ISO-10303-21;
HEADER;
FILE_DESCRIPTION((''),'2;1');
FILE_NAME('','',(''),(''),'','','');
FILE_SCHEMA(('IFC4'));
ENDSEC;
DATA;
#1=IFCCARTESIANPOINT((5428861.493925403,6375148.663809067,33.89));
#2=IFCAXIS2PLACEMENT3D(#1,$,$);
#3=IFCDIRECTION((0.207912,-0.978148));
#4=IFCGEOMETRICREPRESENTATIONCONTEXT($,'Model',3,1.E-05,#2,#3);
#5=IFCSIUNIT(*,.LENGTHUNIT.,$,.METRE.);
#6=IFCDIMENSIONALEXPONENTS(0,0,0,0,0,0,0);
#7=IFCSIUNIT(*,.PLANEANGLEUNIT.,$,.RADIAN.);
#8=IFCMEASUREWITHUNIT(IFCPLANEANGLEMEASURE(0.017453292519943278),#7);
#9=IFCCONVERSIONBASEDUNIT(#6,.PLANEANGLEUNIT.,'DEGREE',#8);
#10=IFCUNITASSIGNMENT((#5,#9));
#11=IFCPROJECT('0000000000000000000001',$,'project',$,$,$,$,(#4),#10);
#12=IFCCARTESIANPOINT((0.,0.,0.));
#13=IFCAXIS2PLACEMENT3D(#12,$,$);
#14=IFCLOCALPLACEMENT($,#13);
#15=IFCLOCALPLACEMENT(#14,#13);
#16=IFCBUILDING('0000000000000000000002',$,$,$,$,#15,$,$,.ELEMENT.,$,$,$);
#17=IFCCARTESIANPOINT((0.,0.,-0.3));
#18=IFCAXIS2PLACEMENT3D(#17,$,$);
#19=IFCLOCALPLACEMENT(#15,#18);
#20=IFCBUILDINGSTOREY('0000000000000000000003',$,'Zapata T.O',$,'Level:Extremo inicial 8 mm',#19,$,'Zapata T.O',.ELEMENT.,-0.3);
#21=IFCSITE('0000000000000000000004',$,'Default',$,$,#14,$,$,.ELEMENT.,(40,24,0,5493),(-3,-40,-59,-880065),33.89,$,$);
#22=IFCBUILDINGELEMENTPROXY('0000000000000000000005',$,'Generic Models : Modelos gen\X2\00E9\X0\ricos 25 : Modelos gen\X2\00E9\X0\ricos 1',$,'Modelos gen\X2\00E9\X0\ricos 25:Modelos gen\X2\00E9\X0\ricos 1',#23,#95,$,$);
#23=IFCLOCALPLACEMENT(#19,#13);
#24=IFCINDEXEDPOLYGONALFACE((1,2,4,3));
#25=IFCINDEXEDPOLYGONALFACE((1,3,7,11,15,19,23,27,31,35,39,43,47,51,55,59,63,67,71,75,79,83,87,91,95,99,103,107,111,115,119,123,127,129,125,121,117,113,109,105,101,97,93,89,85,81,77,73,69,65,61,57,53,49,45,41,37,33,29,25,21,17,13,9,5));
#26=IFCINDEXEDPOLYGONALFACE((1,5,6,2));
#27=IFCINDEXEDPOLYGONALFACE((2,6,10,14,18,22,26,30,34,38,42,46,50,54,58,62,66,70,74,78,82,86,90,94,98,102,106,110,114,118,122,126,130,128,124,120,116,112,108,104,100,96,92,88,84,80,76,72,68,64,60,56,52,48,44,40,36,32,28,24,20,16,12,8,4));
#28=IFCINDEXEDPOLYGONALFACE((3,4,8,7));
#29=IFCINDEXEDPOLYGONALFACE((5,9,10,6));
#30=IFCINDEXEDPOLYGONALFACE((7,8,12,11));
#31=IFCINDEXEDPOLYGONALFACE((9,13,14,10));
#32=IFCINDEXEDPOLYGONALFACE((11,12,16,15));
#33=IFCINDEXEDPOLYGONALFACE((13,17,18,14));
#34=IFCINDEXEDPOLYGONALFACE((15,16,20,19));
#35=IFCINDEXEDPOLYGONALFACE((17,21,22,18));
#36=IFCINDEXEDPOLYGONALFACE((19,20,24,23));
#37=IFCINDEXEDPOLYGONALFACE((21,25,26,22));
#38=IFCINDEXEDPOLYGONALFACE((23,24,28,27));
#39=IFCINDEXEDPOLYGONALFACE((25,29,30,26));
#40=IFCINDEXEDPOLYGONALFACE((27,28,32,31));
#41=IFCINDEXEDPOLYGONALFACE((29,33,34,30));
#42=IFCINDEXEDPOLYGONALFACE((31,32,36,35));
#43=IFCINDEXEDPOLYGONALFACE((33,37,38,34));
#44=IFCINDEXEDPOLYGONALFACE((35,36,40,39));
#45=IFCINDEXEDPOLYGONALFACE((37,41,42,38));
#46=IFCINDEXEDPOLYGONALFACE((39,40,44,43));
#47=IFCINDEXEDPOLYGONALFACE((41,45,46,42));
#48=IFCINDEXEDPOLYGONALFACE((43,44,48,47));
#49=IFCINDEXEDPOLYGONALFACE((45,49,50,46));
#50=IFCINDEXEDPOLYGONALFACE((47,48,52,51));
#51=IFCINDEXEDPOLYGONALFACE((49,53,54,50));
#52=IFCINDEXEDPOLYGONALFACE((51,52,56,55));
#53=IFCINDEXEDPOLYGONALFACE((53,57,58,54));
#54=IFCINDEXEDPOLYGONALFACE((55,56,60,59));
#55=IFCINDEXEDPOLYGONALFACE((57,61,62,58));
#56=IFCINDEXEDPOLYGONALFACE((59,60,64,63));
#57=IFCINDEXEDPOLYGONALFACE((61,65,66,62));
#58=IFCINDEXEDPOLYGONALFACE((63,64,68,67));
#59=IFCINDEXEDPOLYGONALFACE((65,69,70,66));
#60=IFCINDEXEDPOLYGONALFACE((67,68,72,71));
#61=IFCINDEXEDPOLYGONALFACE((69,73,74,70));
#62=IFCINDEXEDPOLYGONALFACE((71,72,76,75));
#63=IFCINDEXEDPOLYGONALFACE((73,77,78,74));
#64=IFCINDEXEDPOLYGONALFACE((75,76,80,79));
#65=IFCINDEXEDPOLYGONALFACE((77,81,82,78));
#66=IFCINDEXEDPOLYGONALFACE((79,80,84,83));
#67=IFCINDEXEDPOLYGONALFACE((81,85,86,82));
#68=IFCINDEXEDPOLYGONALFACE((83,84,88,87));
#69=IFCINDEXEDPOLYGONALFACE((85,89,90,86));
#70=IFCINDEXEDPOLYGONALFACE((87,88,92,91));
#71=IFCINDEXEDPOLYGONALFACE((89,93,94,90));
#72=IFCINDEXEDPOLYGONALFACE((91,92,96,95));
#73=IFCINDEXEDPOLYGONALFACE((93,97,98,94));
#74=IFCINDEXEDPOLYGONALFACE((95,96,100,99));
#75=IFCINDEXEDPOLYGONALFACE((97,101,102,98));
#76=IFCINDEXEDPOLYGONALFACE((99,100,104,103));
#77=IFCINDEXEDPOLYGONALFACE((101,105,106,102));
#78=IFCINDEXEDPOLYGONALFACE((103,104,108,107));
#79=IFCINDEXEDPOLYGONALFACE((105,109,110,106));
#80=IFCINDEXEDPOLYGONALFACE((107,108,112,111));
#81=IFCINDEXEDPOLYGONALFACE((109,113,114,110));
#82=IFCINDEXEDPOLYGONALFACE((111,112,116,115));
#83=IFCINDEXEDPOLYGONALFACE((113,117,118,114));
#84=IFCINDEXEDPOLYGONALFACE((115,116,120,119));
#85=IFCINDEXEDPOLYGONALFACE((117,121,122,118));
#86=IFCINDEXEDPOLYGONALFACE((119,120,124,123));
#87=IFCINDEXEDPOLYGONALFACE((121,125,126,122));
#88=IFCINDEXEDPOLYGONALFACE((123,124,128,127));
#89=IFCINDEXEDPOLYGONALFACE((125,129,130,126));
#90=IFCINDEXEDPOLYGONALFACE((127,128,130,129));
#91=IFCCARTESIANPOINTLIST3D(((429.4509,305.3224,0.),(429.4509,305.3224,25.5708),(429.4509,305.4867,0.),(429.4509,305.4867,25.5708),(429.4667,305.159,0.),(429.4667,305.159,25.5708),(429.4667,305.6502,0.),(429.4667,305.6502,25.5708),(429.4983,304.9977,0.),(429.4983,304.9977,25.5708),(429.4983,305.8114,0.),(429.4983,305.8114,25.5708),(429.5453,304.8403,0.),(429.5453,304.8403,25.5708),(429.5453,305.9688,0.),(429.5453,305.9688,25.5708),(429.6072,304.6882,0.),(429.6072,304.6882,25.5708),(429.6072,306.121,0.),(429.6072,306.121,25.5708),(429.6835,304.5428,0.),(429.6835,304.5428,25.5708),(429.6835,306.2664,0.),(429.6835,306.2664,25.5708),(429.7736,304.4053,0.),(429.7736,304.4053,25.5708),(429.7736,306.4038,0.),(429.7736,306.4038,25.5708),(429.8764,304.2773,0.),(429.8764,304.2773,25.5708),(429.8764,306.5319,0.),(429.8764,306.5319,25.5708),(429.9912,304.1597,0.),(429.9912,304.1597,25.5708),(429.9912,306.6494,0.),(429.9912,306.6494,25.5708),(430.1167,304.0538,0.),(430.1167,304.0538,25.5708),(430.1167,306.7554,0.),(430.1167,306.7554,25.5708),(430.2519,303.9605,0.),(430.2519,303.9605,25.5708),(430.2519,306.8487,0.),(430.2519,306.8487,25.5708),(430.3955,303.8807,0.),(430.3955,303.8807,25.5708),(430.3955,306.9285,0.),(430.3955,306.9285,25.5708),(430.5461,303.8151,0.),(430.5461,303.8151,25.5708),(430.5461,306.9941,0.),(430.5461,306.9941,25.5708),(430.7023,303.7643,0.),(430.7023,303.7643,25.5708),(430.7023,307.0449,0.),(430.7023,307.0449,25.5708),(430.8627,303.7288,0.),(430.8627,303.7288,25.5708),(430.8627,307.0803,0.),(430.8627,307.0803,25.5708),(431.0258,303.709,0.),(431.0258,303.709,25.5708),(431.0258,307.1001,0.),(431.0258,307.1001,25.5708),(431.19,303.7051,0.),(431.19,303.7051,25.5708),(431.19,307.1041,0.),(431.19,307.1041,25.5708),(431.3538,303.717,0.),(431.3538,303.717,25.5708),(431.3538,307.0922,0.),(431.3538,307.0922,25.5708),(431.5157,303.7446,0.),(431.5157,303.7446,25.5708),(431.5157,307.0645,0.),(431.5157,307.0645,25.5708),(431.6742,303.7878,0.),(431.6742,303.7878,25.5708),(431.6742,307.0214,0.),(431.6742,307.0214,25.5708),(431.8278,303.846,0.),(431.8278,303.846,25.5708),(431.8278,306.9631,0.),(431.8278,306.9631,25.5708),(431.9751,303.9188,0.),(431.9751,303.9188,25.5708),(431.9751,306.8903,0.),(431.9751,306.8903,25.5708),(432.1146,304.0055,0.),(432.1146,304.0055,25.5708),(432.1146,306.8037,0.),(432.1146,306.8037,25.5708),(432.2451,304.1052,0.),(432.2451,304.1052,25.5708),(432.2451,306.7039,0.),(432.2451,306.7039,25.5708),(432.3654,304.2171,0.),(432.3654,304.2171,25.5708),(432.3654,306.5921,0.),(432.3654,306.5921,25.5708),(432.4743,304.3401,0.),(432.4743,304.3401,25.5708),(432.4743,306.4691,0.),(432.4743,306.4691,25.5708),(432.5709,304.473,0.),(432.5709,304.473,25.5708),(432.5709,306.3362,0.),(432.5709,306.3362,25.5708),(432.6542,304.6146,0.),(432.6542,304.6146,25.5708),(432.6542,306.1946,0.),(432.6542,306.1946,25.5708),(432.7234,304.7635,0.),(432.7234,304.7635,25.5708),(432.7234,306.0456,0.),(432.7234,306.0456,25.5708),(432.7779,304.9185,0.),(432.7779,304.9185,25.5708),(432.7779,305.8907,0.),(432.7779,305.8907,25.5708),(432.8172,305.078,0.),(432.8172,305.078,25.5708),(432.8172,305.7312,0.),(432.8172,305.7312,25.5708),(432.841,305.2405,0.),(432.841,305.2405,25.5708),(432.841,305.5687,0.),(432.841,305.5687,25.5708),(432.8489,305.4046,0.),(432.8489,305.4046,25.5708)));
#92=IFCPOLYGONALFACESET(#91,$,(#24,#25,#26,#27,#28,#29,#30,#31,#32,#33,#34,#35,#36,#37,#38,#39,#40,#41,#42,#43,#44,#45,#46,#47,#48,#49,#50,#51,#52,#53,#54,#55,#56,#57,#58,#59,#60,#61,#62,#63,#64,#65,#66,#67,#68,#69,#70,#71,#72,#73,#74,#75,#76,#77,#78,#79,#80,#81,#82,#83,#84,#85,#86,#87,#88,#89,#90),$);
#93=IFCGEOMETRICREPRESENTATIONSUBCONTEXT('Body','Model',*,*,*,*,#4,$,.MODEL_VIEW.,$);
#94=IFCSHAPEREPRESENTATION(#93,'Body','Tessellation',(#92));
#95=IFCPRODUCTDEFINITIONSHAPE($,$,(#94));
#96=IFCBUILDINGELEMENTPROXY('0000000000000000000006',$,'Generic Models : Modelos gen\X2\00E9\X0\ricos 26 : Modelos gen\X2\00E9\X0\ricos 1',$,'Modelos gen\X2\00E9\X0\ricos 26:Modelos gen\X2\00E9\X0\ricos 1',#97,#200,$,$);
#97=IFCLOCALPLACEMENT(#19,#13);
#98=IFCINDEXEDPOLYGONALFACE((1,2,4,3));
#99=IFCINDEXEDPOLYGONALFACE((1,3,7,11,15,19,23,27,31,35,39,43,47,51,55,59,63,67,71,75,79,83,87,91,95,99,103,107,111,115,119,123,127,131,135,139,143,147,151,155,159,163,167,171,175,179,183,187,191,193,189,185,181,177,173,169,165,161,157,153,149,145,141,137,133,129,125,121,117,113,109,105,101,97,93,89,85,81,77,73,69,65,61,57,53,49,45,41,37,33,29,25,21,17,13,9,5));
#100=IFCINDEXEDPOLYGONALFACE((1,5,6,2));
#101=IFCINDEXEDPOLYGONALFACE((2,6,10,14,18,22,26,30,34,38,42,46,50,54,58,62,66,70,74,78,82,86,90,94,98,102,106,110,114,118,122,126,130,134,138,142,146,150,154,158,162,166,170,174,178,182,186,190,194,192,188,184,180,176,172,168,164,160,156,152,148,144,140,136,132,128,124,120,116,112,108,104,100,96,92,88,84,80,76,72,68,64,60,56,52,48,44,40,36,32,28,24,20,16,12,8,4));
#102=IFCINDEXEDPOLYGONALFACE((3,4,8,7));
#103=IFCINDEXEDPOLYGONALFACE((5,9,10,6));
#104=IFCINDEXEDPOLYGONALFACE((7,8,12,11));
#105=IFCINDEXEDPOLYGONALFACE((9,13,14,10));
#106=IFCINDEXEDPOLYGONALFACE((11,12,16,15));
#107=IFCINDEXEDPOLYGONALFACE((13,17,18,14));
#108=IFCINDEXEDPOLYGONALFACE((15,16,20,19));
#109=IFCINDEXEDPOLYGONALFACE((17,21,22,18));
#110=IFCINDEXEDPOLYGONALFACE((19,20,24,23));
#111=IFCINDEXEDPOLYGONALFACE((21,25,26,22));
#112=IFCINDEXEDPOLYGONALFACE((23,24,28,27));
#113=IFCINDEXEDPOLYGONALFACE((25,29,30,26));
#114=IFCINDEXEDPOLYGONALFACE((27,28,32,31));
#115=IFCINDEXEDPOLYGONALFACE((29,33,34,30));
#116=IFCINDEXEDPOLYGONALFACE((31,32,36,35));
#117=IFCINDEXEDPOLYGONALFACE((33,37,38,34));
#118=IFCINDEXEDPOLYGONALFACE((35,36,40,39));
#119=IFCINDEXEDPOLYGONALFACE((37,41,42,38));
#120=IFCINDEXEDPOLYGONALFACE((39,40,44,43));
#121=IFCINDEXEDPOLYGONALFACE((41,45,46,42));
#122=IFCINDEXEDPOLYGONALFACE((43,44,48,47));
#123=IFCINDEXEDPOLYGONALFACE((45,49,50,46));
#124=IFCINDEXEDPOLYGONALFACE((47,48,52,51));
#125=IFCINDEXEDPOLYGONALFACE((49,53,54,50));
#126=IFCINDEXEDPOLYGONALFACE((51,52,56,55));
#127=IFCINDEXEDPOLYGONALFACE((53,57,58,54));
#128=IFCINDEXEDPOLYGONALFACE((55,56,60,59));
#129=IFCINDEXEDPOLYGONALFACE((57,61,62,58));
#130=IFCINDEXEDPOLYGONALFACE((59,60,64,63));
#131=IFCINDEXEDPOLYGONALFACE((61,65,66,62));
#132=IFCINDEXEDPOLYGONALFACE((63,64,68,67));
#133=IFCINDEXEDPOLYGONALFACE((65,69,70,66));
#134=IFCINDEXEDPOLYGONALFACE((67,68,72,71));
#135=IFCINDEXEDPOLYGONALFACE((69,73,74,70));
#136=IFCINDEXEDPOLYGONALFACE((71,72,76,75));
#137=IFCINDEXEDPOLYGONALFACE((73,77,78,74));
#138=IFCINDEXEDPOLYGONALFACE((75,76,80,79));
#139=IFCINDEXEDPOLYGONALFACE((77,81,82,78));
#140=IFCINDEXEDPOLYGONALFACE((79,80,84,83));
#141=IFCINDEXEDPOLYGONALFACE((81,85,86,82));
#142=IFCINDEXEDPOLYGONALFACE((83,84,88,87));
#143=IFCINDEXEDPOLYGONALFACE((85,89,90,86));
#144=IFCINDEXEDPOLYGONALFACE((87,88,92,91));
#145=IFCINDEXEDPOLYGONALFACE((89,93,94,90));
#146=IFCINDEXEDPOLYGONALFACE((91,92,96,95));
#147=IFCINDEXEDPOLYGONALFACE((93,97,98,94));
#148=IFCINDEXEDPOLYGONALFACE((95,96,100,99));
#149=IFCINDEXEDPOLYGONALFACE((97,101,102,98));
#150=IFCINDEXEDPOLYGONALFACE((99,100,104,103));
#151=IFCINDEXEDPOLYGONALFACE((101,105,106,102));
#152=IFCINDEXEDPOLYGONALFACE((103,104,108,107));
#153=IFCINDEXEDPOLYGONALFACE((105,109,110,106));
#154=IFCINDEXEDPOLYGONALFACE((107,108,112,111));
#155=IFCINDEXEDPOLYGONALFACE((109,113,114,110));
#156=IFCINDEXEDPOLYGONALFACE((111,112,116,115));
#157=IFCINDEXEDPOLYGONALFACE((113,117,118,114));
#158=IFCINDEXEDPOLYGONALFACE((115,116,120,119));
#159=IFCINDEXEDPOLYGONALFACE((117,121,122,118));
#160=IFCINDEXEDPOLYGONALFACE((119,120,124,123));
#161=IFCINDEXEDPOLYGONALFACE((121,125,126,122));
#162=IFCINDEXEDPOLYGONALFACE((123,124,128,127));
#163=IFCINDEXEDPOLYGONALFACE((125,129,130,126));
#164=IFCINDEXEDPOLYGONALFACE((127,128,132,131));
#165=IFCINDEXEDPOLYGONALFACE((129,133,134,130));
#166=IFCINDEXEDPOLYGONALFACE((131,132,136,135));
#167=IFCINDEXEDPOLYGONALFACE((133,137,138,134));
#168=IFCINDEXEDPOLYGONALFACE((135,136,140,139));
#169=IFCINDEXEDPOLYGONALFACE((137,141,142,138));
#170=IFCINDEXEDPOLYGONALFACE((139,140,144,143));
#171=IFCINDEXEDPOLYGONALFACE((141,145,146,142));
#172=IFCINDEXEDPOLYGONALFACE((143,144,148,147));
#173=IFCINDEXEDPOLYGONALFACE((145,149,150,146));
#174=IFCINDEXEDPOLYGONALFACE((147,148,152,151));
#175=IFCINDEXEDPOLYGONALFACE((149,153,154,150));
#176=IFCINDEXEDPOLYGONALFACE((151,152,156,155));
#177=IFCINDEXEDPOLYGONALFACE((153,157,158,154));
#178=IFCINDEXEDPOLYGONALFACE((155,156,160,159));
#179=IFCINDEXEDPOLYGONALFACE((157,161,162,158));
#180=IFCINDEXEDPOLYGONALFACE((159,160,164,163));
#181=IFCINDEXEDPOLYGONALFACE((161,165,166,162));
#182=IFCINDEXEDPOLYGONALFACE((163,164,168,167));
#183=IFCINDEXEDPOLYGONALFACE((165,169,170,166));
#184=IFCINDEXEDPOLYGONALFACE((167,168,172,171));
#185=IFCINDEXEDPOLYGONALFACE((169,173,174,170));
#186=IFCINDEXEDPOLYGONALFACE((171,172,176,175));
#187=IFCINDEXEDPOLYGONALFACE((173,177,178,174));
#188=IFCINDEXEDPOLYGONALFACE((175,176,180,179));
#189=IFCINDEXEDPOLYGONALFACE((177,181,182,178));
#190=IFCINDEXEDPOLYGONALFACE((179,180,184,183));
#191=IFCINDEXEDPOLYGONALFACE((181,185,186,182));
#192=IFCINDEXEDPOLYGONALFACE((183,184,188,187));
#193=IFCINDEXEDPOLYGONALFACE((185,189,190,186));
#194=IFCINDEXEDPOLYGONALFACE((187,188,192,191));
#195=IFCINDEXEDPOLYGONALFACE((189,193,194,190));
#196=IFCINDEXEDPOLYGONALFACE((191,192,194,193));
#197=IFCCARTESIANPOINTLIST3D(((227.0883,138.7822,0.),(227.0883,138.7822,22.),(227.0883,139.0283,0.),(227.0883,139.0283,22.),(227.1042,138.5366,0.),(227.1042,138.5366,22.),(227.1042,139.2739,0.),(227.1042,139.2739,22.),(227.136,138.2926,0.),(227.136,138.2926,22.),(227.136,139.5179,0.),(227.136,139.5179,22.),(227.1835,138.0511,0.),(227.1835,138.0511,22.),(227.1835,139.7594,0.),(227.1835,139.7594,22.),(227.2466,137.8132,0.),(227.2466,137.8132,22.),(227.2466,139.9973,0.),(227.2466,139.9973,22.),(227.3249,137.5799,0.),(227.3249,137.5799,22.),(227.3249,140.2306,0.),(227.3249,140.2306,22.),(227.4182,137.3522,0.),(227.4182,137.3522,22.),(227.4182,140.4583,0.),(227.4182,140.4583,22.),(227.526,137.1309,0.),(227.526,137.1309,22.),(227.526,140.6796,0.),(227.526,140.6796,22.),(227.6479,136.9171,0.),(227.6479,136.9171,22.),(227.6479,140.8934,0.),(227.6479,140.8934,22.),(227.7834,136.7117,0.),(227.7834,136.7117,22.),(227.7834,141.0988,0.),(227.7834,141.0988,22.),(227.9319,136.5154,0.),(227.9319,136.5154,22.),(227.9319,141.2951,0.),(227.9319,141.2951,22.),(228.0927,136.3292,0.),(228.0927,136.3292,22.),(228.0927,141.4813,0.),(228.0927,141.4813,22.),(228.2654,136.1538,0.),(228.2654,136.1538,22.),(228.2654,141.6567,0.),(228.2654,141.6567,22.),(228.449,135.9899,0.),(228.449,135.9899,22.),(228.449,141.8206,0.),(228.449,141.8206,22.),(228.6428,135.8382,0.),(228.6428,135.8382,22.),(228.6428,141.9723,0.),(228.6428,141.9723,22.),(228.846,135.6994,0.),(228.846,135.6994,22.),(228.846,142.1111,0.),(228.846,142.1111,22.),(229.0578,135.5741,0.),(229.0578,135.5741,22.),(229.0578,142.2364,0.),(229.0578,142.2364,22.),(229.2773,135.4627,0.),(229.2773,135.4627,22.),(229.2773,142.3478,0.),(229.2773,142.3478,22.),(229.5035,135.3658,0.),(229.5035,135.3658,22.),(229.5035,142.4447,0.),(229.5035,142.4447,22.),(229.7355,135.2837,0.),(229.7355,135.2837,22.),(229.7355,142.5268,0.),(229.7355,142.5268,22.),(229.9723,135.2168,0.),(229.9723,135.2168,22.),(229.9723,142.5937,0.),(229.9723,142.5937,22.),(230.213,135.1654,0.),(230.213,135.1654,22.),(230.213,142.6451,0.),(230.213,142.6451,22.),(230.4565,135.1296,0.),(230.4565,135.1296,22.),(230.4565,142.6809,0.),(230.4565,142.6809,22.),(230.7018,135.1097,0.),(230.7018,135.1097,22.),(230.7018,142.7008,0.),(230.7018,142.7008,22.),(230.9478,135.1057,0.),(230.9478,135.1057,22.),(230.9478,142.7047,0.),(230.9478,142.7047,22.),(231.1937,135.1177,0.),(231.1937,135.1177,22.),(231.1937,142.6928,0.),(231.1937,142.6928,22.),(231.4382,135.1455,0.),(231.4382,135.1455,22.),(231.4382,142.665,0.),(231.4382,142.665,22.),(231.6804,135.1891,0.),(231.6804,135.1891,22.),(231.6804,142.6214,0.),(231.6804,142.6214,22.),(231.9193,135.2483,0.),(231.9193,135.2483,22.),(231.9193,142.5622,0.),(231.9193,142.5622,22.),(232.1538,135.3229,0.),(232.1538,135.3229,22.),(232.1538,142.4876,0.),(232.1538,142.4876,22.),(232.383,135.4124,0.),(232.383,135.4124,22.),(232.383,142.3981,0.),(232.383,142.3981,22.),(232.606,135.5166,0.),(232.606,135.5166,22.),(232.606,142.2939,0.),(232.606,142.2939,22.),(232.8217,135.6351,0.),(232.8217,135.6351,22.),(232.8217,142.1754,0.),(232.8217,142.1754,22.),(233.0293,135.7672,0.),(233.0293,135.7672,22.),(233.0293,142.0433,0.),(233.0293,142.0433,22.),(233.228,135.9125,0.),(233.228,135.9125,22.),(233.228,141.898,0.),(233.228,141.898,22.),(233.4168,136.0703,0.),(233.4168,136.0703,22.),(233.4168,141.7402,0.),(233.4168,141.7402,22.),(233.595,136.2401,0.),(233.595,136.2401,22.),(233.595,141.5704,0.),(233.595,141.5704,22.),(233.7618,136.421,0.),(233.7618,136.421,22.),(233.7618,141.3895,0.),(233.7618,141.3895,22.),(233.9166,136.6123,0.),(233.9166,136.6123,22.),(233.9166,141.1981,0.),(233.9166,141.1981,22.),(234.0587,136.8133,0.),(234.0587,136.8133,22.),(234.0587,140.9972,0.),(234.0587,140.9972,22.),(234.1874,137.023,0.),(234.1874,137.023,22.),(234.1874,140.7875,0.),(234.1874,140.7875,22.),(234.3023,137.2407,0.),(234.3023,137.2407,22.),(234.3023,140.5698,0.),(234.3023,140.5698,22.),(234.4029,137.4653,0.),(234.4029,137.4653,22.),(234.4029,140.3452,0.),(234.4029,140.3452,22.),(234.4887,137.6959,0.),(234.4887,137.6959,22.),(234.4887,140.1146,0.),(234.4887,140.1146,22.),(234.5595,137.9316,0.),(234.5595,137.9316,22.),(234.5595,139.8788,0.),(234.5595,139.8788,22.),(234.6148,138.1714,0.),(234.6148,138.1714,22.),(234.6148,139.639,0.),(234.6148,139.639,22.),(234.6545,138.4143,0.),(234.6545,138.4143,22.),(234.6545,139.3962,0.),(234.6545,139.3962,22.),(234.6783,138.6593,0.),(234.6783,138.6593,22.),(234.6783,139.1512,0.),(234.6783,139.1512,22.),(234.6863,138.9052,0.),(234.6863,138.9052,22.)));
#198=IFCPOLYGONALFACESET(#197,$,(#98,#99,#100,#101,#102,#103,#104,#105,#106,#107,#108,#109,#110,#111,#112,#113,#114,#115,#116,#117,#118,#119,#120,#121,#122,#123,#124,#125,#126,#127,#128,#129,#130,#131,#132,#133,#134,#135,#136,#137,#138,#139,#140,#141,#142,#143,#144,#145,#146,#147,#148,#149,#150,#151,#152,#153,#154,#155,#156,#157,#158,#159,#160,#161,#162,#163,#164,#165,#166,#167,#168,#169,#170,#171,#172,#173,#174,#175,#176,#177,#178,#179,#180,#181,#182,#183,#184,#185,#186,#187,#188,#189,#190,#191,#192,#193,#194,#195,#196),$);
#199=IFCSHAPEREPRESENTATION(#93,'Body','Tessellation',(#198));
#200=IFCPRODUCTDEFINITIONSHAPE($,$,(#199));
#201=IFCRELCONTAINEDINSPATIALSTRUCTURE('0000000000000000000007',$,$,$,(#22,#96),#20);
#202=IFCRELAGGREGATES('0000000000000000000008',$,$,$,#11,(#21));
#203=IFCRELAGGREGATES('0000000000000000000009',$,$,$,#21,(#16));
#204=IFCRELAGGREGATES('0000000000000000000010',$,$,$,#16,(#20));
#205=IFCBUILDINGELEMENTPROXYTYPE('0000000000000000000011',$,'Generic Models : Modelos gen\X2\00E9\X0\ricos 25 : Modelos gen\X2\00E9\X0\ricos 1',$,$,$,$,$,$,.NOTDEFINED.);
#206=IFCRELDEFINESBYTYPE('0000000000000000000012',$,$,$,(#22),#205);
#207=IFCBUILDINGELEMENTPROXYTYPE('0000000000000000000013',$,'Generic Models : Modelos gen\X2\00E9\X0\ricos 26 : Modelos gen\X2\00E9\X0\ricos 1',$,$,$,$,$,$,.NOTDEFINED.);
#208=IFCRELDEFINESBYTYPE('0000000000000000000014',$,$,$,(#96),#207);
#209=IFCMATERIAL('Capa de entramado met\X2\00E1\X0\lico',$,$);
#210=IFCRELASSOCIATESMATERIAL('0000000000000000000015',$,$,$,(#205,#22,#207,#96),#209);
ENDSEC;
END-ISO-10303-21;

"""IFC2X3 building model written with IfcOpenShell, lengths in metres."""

from ifc_helpers import new_model, entity, si_unit, converted_unit, direction, frame, frame_2d, origin, origin_2d_with_axis, place, context, subcontext, project, spatial, circle, extrude, source, transform, mapped, material, type_object, type_shapes, element, save


model = new_model("IFC2X3")

# Units and contexts
model_context = context("Model", 3, precision=1e-05, world=frame((5428861.493925403, 6375148.663809067, 33.89)), true_north=direction((0.207912, -0.978148)))
body_context = subcontext(model_context, "Body", "Model", "MODEL_VIEW")
ifc_project = project(units=[si_unit("LENGTHUNIT", "METRE"), converted_unit("PLANEANGLEUNIT", "DEGREE", entity("IfcPlaneAngleMeasure", 0.017453292519943278), si_unit("PLANEANGLEUNIT", "RADIAN"), dimensions=[0, 0, 0, 0, 0, 0, 0])], contexts=[model_context])

# Site, building, storey
site_placement = place(None, origin())
site = spatial("IfcSite", under=ifc_project, at=site_placement, Name="Default", CompositionType="ELEMENT", RefLatitude=(40, 24, 0, 5493), RefLongitude=(-3, -40, -59, -880065), RefElevation=33.89)
building_placement = place(site_placement, origin())
building = spatial("IfcBuilding", under=site, at=building_placement, CompositionType="ELEMENT")
storey_placement = place(building_placement, frame((0.0, 0.0, -0.3)))
storey = spatial("IfcBuildingStorey", under=building, at=storey_placement, Name="Zapata T.O", ObjectType="Level:Extremo inicial 8 mm", LongName="Zapata T.O", CompositionType="ELEMENT", Elevation=-0.3)

# Building element proxies
ifc_material = material(Name="Capa de entramado metálico")
building_element_proxy_type_1 = type_object("IfcBuildingElementProxyType", Name="Generic Models : Modelos genéricos 25 : Modelos genéricos 1", PredefinedType="NOTDEFINED", material=ifc_material)
shared_shape_1 = source(origin(), body_context, "Body", "SweptSolid", [
    extrude(circle(Radius=1.7, at=origin_2d_with_axis()), frame((431.1489, 305.4046, -0.3)), (0.0, 0.0, 1.0), 25.5708),
])
type_shapes(building_element_proxy_type_1, [shared_shape_1])
proxy_1_placement = place(storey_placement, frame((0.0, 0.0, 0.3)))
element("IfcBuildingElementProxy", 1, at=proxy_1_placement, inside=storey, type_object=building_element_proxy_type_1, material=ifc_material, Name="Generic Models : Modelos genéricos 25 : Modelos genéricos 1", ObjectType="Modelos genéricos 25:Modelos genéricos 1", context=body_context, shape_type="MappedRepresentation", body=[
    mapped(shared_shape_1, transform((0.0, 0.0, 0.0), scale=1.0)),
])
building_element_proxy_type_2 = type_object("IfcBuildingElementProxyType", Name="Generic Models : Modelos genéricos 26 : Modelos genéricos 1", PredefinedType="NOTDEFINED", material=ifc_material)
shared_shape_2 = source(origin(), body_context, "Body", "SweptSolid", [
    extrude(circle(Radius=3.8, at=frame_2d((0.0, 0.0), x_axis=(1.0, 0.0))), frame((230.8863, 138.9052, -0.3)), (0.0, 0.0, 1.0), 22.0),
])
type_shapes(building_element_proxy_type_2, [shared_shape_2])
proxy_2_placement = place(storey_placement, frame((0.0, 0.0, 0.3)))
element("IfcBuildingElementProxy", 2, at=proxy_2_placement, inside=storey, type_object=building_element_proxy_type_2, material=ifc_material, Name="Generic Models : Modelos genéricos 26 : Modelos genéricos 1", ObjectType="Modelos genéricos 26:Modelos genéricos 1", context=body_context, shape_type="MappedRepresentation", body=[
    mapped(shared_shape_2, transform((0.0, 0.0, 0.0), scale=1.0)),
])

save(model, "model.ifc")
